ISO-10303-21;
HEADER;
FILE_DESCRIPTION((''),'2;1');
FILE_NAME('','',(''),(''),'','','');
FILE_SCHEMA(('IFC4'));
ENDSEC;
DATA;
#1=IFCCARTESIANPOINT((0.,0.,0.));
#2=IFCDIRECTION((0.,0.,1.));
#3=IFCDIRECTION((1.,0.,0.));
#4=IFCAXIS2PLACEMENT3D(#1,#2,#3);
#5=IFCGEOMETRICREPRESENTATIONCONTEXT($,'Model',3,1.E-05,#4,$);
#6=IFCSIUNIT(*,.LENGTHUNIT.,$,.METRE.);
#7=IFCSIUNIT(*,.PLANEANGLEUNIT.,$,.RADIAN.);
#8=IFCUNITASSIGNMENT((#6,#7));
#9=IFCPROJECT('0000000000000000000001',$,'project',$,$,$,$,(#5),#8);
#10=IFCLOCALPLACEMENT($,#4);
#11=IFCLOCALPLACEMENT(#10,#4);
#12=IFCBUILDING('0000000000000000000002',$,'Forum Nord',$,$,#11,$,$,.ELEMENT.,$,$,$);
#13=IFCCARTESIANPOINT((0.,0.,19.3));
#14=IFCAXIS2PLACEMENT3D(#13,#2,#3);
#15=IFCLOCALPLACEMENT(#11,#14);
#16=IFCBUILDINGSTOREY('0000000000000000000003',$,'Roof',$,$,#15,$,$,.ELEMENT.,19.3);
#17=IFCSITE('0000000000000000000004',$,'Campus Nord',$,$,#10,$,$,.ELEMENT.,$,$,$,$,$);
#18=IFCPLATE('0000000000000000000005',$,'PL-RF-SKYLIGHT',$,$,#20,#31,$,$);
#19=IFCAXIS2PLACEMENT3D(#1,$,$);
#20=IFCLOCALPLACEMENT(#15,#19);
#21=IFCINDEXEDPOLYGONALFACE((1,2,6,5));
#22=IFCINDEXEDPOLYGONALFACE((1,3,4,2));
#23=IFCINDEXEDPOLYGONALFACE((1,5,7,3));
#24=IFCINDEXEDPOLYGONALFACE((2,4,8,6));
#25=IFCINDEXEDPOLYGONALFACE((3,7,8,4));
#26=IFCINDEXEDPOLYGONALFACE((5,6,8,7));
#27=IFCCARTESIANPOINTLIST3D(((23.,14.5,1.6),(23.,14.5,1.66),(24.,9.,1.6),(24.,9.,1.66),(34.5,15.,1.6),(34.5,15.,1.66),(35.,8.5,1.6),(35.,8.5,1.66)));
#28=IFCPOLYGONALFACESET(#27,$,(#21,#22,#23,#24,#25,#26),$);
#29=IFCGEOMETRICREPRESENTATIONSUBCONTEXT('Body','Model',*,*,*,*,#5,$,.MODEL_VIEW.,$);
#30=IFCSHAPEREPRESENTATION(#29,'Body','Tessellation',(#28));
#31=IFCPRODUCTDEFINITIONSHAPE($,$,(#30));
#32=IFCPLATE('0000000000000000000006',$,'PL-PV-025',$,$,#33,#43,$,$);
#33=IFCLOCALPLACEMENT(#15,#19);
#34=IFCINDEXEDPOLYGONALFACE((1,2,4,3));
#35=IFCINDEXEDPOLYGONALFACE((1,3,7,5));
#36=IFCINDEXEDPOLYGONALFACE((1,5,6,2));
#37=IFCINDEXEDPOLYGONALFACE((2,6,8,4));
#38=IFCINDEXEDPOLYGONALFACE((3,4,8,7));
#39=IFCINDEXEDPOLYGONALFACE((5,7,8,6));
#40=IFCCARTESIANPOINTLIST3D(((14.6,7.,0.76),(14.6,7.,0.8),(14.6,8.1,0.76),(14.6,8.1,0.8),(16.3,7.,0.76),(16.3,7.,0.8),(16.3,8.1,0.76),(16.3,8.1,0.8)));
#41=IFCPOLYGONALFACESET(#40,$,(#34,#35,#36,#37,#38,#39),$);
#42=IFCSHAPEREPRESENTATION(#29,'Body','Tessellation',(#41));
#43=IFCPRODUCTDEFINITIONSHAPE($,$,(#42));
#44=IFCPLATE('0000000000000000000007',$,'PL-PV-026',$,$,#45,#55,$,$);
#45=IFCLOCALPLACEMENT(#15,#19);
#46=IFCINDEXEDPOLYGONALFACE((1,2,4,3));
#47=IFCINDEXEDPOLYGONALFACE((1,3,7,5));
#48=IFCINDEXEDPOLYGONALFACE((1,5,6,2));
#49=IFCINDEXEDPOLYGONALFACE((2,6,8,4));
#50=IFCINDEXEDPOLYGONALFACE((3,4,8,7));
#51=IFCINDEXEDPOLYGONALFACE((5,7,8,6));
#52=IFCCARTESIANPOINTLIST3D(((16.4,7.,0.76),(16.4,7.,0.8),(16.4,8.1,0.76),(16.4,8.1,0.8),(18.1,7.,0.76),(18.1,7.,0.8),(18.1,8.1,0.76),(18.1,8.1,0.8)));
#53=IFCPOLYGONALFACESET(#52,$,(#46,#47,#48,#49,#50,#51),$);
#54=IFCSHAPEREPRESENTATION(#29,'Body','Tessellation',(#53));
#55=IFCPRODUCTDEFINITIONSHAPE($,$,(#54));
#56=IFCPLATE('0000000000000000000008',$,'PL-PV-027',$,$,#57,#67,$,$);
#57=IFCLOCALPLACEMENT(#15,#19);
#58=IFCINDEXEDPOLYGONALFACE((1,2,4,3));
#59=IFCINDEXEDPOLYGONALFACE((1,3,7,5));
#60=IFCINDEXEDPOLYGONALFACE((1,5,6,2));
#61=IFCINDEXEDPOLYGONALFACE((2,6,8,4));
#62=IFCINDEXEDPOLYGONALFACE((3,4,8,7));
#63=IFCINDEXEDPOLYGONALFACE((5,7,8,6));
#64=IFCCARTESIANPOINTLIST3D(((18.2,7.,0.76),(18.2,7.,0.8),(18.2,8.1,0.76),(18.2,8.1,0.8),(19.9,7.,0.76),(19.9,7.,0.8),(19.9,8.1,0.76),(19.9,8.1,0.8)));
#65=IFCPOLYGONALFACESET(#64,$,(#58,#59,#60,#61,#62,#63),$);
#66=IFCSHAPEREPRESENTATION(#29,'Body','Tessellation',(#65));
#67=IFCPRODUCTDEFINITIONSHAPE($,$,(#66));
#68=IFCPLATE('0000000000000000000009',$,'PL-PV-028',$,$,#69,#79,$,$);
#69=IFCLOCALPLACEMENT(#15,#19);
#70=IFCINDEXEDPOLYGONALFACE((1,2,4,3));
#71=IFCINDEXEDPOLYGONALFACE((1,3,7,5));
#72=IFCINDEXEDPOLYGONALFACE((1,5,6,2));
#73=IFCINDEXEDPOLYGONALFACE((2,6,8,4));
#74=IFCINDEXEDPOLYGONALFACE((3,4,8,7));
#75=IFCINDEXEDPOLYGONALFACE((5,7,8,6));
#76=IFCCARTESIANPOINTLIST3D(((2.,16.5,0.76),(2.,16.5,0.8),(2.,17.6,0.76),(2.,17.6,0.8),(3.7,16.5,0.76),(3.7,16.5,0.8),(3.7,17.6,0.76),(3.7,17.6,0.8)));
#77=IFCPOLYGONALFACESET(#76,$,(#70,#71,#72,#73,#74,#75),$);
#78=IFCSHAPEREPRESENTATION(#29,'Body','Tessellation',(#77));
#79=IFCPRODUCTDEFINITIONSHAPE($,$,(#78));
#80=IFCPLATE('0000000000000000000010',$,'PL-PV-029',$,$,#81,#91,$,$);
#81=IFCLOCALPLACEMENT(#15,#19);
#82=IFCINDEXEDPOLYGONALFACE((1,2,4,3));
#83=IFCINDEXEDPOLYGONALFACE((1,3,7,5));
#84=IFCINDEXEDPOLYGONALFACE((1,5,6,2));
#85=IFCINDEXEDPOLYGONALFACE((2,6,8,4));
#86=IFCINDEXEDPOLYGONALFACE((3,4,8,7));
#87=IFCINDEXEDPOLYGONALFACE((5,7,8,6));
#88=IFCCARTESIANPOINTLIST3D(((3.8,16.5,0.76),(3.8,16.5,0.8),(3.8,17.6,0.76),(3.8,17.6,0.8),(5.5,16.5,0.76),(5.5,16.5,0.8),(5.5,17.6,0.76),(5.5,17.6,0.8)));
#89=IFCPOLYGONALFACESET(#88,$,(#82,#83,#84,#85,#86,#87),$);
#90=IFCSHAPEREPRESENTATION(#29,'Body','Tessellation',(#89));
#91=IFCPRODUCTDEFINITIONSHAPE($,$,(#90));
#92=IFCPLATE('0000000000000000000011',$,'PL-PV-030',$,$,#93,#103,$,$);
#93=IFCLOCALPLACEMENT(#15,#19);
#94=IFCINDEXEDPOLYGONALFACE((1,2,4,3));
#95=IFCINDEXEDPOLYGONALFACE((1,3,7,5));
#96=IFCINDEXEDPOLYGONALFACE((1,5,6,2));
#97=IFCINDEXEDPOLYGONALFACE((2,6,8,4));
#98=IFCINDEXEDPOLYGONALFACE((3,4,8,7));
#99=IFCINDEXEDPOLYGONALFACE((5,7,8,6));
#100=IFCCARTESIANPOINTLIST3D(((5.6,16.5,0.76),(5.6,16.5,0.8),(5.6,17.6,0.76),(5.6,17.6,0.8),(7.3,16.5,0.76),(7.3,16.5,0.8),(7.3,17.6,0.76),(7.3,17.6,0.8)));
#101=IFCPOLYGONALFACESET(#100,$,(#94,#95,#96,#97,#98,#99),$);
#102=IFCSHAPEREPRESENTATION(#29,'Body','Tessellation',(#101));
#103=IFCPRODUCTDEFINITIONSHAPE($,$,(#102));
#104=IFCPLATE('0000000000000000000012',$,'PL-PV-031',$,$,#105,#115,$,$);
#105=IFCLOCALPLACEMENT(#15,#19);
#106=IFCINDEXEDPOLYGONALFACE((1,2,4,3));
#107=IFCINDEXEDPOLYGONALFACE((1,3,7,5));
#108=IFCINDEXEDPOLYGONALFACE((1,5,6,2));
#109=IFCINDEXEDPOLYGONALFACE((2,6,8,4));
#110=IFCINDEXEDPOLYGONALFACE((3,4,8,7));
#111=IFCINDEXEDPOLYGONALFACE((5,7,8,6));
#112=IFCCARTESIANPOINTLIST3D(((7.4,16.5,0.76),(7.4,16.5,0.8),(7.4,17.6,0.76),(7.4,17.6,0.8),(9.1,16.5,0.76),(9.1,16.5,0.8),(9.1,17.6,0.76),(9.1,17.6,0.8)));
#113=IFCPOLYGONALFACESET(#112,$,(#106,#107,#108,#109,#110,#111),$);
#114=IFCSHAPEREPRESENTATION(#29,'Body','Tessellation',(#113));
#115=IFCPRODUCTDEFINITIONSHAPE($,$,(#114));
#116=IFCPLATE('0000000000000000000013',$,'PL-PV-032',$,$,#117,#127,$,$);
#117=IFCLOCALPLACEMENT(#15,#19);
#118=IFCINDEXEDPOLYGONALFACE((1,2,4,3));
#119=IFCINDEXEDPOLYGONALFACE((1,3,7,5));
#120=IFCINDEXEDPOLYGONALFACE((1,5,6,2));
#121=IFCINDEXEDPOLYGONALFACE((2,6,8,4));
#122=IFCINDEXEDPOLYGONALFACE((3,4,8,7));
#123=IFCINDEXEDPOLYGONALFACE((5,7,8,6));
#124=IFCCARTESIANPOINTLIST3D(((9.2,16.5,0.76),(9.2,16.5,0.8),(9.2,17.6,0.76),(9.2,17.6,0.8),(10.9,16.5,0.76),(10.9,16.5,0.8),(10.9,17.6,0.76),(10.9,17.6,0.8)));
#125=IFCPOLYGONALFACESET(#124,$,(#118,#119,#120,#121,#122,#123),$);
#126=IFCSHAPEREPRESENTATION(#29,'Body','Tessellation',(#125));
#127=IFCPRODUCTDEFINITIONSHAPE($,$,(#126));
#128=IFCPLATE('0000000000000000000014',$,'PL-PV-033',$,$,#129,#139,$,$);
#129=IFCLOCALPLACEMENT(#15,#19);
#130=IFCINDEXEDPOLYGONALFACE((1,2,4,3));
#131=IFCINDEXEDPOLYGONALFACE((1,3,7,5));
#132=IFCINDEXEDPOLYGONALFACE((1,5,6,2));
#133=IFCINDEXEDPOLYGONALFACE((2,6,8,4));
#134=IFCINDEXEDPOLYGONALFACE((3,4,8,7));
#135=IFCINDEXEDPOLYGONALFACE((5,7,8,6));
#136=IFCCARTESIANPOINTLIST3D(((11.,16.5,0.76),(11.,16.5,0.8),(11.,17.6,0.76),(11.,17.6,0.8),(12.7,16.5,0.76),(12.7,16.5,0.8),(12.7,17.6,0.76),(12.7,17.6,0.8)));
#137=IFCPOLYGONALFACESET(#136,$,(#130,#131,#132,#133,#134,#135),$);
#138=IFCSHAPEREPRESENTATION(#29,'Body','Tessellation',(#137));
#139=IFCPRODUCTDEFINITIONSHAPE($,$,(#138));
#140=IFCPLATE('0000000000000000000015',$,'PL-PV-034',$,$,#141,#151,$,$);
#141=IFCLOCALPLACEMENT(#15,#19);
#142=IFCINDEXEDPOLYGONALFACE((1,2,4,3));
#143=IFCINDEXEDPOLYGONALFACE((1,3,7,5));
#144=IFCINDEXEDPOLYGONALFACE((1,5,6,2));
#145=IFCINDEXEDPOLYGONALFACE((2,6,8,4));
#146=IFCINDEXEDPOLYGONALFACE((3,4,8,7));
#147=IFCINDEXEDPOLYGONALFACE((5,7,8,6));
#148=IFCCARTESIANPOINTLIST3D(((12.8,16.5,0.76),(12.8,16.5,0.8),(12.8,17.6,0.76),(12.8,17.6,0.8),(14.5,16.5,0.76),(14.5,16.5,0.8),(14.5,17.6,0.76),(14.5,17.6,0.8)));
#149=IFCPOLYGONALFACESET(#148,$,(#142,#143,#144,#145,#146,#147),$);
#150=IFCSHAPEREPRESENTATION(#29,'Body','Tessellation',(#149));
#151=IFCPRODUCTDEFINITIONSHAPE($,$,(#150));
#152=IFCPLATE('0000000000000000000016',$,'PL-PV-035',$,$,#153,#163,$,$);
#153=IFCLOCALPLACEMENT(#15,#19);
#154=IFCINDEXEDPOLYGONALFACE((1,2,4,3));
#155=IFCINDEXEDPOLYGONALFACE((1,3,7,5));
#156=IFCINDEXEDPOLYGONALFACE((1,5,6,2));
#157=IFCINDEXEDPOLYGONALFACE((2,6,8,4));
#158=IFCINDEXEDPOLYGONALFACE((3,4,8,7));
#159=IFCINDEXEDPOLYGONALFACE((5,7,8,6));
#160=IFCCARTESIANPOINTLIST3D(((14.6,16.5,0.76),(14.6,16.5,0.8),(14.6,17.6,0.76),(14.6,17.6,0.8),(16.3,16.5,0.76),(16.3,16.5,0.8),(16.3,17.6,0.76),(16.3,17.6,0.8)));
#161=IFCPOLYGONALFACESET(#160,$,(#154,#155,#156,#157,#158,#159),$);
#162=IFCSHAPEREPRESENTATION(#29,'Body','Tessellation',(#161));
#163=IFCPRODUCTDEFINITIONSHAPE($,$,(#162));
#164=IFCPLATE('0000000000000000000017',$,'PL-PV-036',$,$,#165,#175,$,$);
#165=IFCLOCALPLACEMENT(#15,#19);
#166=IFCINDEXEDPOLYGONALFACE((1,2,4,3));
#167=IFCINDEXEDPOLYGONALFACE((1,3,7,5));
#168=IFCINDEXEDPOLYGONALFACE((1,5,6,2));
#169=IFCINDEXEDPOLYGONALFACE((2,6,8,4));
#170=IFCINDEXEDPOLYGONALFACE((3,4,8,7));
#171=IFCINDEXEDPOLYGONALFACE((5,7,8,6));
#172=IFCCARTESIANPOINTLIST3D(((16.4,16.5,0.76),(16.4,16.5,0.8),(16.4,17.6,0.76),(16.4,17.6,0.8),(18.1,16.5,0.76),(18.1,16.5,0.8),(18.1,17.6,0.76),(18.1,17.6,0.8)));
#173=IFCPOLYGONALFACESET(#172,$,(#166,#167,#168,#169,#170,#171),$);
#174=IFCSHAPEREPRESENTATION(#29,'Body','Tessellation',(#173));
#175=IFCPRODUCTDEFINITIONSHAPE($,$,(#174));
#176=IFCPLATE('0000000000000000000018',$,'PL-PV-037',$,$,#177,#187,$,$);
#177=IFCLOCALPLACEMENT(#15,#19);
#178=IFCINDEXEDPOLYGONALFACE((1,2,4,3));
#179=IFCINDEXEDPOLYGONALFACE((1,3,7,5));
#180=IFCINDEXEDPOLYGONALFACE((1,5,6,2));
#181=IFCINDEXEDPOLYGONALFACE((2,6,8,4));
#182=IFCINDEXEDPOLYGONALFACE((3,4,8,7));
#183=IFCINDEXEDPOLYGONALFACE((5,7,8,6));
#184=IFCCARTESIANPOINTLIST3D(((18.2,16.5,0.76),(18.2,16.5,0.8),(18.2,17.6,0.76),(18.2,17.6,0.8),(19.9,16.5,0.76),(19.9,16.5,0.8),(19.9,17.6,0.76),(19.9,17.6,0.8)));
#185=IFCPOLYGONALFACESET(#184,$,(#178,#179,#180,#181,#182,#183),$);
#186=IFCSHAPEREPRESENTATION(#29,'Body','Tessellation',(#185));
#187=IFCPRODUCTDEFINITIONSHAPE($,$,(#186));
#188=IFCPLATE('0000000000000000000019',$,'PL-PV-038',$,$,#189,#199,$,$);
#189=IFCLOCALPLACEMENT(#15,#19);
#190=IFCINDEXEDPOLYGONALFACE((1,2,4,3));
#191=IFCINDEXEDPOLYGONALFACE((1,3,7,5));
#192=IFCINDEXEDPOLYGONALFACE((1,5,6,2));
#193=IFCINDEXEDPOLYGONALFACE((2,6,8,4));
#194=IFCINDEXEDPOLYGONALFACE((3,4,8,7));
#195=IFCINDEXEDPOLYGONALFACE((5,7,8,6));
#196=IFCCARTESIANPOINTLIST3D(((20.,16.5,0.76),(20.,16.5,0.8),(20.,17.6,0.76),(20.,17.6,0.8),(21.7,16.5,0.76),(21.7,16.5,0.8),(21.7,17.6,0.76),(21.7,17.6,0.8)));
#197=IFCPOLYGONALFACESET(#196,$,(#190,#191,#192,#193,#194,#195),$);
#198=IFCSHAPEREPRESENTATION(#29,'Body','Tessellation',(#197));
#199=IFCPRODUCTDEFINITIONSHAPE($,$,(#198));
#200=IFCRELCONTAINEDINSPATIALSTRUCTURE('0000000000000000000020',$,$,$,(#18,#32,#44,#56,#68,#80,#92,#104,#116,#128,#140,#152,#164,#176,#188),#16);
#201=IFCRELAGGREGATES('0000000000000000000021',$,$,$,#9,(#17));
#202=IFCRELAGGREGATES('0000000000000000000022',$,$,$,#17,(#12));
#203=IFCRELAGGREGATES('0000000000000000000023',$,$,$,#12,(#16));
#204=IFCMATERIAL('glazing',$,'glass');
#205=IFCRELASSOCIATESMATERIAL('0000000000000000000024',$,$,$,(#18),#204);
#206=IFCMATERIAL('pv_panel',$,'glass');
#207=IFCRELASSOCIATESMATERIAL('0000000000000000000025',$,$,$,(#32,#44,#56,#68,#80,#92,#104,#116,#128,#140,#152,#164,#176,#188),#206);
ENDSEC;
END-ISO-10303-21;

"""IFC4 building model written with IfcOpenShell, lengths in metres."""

from ifc_helpers import new_model, si_unit, frame, origin_with_axes, place, context, subcontext, project, spatial, polyline, outline, extrude, material, element, save


model = new_model("IFC4")

# Units and contexts
model_context = context("Model", 3, precision=1e-05, world=origin_with_axes())
body_context = subcontext(model_context, "Body", "Model", "MODEL_VIEW")
ifc_project = project(units=[si_unit("LENGTHUNIT", "METRE"), si_unit("PLANEANGLEUNIT", "RADIAN")], contexts=[model_context])

# Site, building, storey
site_placement = place(None, origin_with_axes())
site = spatial("IfcSite", under=ifc_project, at=site_placement, Name="Campus Nord", CompositionType="ELEMENT")
building_placement = place(site_placement, origin_with_axes())
building = spatial("IfcBuilding", under=site, at=building_placement, Name="Forum Nord", CompositionType="ELEMENT")
storey_placement = place(building_placement, frame((0.0, 0.0, 19.3), z_axis=(0.0, 0.0, 1.0), x_axis=(1.0, 0.0, 0.0)))
storey = spatial("IfcBuildingStorey", under=building, at=storey_placement, Name="Roof", CompositionType="ELEMENT", Elevation=19.3)

# Plates
ifc_material_1 = material(Name="glazing", Category="glass")
plate_1_placement = place(storey_placement, frame((0.0, 0.0, 1.66), z_axis=(0.0, 0.0, 1.0), x_axis=(1.0, 0.0, 0.0)))
element("IfcPlate", 1, at=plate_1_placement, inside=storey, material=ifc_material_1, Name="PL-RF-SKYLIGHT", context=body_context, shape_type="SweptSolid", body=[
    extrude(outline(polyline([(24.0, 9.0), (35.0, 8.5), (34.5, 15.0), (23.0, 14.5), (24.0, 9.0)])), frame((0.0, 0.0, -0.06), z_axis=(0.0, 0.0, 1.0), x_axis=(1.0, 0.0, 0.0)), (0.0, 0.0, 1.0), 0.06),
])
ifc_material_2 = material(Name="pv_panel", Category="glass")
plate_2_placement = place(storey_placement, frame((0.0, 0.0, 0.8), z_axis=(0.0, 0.0, 1.0), x_axis=(1.0, 0.0, 0.0)))
element("IfcPlate", 2, at=plate_2_placement, inside=storey, material=ifc_material_2, Name="PL-PV-025", context=body_context, shape_type="SweptSolid", body=[
    extrude(outline(polyline([(14.6, 7.0), (16.3, 7.0), (16.3, 8.1), (14.6, 8.1), (14.6, 7.0)])), frame((0.0, 0.0, -0.04), z_axis=(0.0, 0.0, 1.0), x_axis=(1.0, 0.0, 0.0)), (0.0, 0.0, 1.0), 0.04),
])
plate_3_placement = place(storey_placement, frame((0.0, 0.0, 0.8), z_axis=(0.0, 0.0, 1.0), x_axis=(1.0, 0.0, 0.0)))
element("IfcPlate", 3, at=plate_3_placement, inside=storey, material=ifc_material_2, Name="PL-PV-026", context=body_context, shape_type="SweptSolid", body=[
    extrude(outline(polyline([(16.4, 7.0), (18.1, 7.0), (18.1, 8.1), (16.4, 8.1), (16.4, 7.0)])), frame((0.0, 0.0, -0.04), z_axis=(0.0, 0.0, 1.0), x_axis=(1.0, 0.0, 0.0)), (0.0, 0.0, 1.0), 0.04),
])
plate_4_placement = place(storey_placement, frame((0.0, 0.0, 0.8), z_axis=(0.0, 0.0, 1.0), x_axis=(1.0, 0.0, 0.0)))
element("IfcPlate", 4, at=plate_4_placement, inside=storey, material=ifc_material_2, Name="PL-PV-027", context=body_context, shape_type="SweptSolid", body=[
    extrude(outline(polyline([(18.2, 7.0), (19.9, 7.0), (19.9, 8.1), (18.2, 8.1), (18.2, 7.0)])), frame((0.0, 0.0, -0.04), z_axis=(0.0, 0.0, 1.0), x_axis=(1.0, 0.0, 0.0)), (0.0, 0.0, 1.0), 0.04),
])
plate_5_placement = place(storey_placement, frame((0.0, 0.0, 0.8), z_axis=(0.0, 0.0, 1.0), x_axis=(1.0, 0.0, 0.0)))
element("IfcPlate", 5, at=plate_5_placement, inside=storey, material=ifc_material_2, Name="PL-PV-028", context=body_context, shape_type="SweptSolid", body=[
    extrude(outline(polyline([(2.0, 16.5), (3.7, 16.5), (3.7, 17.6), (2.0, 17.6), (2.0, 16.5)])), frame((0.0, 0.0, -0.04), z_axis=(0.0, 0.0, 1.0), x_axis=(1.0, 0.0, 0.0)), (0.0, 0.0, 1.0), 0.04),
])
plate_6_placement = place(storey_placement, frame((0.0, 0.0, 0.8), z_axis=(0.0, 0.0, 1.0), x_axis=(1.0, 0.0, 0.0)))
element("IfcPlate", 6, at=plate_6_placement, inside=storey, material=ifc_material_2, Name="PL-PV-029", context=body_context, shape_type="SweptSolid", body=[
    extrude(outline(polyline([(3.8, 16.5), (5.5, 16.5), (5.5, 17.6), (3.8, 17.6), (3.8, 16.5)])), frame((0.0, 0.0, -0.04), z_axis=(0.0, 0.0, 1.0), x_axis=(1.0, 0.0, 0.0)), (0.0, 0.0, 1.0), 0.04),
])
plate_7_placement = place(storey_placement, frame((0.0, 0.0, 0.8), z_axis=(0.0, 0.0, 1.0), x_axis=(1.0, 0.0, 0.0)))
element("IfcPlate", 7, at=plate_7_placement, inside=storey, material=ifc_material_2, Name="PL-PV-030", context=body_context, shape_type="SweptSolid", body=[
    extrude(outline(polyline([(5.6, 16.5), (7.3, 16.5), (7.3, 17.6), (5.6, 17.6), (5.6, 16.5)])), frame((0.0, 0.0, -0.04), z_axis=(0.0, 0.0, 1.0), x_axis=(1.0, 0.0, 0.0)), (0.0, 0.0, 1.0), 0.04),
])
plate_8_placement = place(storey_placement, frame((0.0, 0.0, 0.8), z_axis=(0.0, 0.0, 1.0), x_axis=(1.0, 0.0, 0.0)))
element("IfcPlate", 8, at=plate_8_placement, inside=storey, material=ifc_material_2, Name="PL-PV-031", context=body_context, shape_type="SweptSolid", body=[
    extrude(outline(polyline([(7.4, 16.5), (9.1, 16.5), (9.1, 17.6), (7.4, 17.6), (7.4, 16.5)])), frame((0.0, 0.0, -0.04), z_axis=(0.0, 0.0, 1.0), x_axis=(1.0, 0.0, 0.0)), (0.0, 0.0, 1.0), 0.04),
])
plate_9_placement = place(storey_placement, frame((0.0, 0.0, 0.8), z_axis=(0.0, 0.0, 1.0), x_axis=(1.0, 0.0, 0.0)))
element("IfcPlate", 9, at=plate_9_placement, inside=storey, material=ifc_material_2, Name="PL-PV-032", context=body_context, shape_type="SweptSolid", body=[
    extrude(outline(polyline([(9.2, 16.5), (10.9, 16.5), (10.9, 17.6), (9.2, 17.6), (9.2, 16.5)])), frame((0.0, 0.0, -0.04), z_axis=(0.0, 0.0, 1.0), x_axis=(1.0, 0.0, 0.0)), (0.0, 0.0, 1.0), 0.04),
])
plate_10_placement = place(storey_placement, frame((0.0, 0.0, 0.8), z_axis=(0.0, 0.0, 1.0), x_axis=(1.0, 0.0, 0.0)))
element("IfcPlate", 10, at=plate_10_placement, inside=storey, material=ifc_material_2, Name="PL-PV-033", context=body_context, shape_type="SweptSolid", body=[
    extrude(outline(polyline([(11.0, 16.5), (12.7, 16.5), (12.7, 17.6), (11.0, 17.6), (11.0, 16.5)])), frame((0.0, 0.0, -0.04), z_axis=(0.0, 0.0, 1.0), x_axis=(1.0, 0.0, 0.0)), (0.0, 0.0, 1.0), 0.04),
])
plate_11_placement = place(storey_placement, frame((0.0, 0.0, 0.8), z_axis=(0.0, 0.0, 1.0), x_axis=(1.0, 0.0, 0.0)))
element("IfcPlate", 11, at=plate_11_placement, inside=storey, material=ifc_material_2, Name="PL-PV-034", context=body_context, shape_type="SweptSolid", body=[
    extrude(outline(polyline([(12.8, 16.5), (14.5, 16.5), (14.5, 17.6), (12.8, 17.6), (12.8, 16.5)])), frame((0.0, 0.0, -0.04), z_axis=(0.0, 0.0, 1.0), x_axis=(1.0, 0.0, 0.0)), (0.0, 0.0, 1.0), 0.04),
])
plate_12_placement = place(storey_placement, frame((0.0, 0.0, 0.8), z_axis=(0.0, 0.0, 1.0), x_axis=(1.0, 0.0, 0.0)))
element("IfcPlate", 12, at=plate_12_placement, inside=storey, material=ifc_material_2, Name="PL-PV-035", context=body_context, shape_type="SweptSolid", body=[
    extrude(outline(polyline([(14.6, 16.5), (16.3, 16.5), (16.3, 17.6), (14.6, 17.6), (14.6, 16.5)])), frame((0.0, 0.0, -0.04), z_axis=(0.0, 0.0, 1.0), x_axis=(1.0, 0.0, 0.0)), (0.0, 0.0, 1.0), 0.04),
])
plate_13_placement = place(storey_placement, frame((0.0, 0.0, 0.8), z_axis=(0.0, 0.0, 1.0), x_axis=(1.0, 0.0, 0.0)))
element("IfcPlate", 13, at=plate_13_placement, inside=storey, material=ifc_material_2, Name="PL-PV-036", context=body_context, shape_type="SweptSolid", body=[
    extrude(outline(polyline([(16.4, 16.5), (18.1, 16.5), (18.1, 17.6), (16.4, 17.6), (16.4, 16.5)])), frame((0.0, 0.0, -0.04), z_axis=(0.0, 0.0, 1.0), x_axis=(1.0, 0.0, 0.0)), (0.0, 0.0, 1.0), 0.04),
])
plate_14_placement = place(storey_placement, frame((0.0, 0.0, 0.8), z_axis=(0.0, 0.0, 1.0), x_axis=(1.0, 0.0, 0.0)))
element("IfcPlate", 14, at=plate_14_placement, inside=storey, material=ifc_material_2, Name="PL-PV-037", context=body_context, shape_type="SweptSolid", body=[
    extrude(outline(polyline([(18.2, 16.5), (19.9, 16.5), (19.9, 17.6), (18.2, 17.6), (18.2, 16.5)])), frame((0.0, 0.0, -0.04), z_axis=(0.0, 0.0, 1.0), x_axis=(1.0, 0.0, 0.0)), (0.0, 0.0, 1.0), 0.04),
])
plate_15_placement = place(storey_placement, frame((0.0, 0.0, 0.8), z_axis=(0.0, 0.0, 1.0), x_axis=(1.0, 0.0, 0.0)))
element("IfcPlate", 15, at=plate_15_placement, inside=storey, material=ifc_material_2, Name="PL-PV-038", context=body_context, shape_type="SweptSolid", body=[
    extrude(outline(polyline([(20.0, 16.5), (21.7, 16.5), (21.7, 17.6), (20.0, 17.6), (20.0, 16.5)])), frame((0.0, 0.0, -0.04), z_axis=(0.0, 0.0, 1.0), x_axis=(1.0, 0.0, 0.0)), (0.0, 0.0, 1.0), 0.04),
])

save(model, "model.ifc")
